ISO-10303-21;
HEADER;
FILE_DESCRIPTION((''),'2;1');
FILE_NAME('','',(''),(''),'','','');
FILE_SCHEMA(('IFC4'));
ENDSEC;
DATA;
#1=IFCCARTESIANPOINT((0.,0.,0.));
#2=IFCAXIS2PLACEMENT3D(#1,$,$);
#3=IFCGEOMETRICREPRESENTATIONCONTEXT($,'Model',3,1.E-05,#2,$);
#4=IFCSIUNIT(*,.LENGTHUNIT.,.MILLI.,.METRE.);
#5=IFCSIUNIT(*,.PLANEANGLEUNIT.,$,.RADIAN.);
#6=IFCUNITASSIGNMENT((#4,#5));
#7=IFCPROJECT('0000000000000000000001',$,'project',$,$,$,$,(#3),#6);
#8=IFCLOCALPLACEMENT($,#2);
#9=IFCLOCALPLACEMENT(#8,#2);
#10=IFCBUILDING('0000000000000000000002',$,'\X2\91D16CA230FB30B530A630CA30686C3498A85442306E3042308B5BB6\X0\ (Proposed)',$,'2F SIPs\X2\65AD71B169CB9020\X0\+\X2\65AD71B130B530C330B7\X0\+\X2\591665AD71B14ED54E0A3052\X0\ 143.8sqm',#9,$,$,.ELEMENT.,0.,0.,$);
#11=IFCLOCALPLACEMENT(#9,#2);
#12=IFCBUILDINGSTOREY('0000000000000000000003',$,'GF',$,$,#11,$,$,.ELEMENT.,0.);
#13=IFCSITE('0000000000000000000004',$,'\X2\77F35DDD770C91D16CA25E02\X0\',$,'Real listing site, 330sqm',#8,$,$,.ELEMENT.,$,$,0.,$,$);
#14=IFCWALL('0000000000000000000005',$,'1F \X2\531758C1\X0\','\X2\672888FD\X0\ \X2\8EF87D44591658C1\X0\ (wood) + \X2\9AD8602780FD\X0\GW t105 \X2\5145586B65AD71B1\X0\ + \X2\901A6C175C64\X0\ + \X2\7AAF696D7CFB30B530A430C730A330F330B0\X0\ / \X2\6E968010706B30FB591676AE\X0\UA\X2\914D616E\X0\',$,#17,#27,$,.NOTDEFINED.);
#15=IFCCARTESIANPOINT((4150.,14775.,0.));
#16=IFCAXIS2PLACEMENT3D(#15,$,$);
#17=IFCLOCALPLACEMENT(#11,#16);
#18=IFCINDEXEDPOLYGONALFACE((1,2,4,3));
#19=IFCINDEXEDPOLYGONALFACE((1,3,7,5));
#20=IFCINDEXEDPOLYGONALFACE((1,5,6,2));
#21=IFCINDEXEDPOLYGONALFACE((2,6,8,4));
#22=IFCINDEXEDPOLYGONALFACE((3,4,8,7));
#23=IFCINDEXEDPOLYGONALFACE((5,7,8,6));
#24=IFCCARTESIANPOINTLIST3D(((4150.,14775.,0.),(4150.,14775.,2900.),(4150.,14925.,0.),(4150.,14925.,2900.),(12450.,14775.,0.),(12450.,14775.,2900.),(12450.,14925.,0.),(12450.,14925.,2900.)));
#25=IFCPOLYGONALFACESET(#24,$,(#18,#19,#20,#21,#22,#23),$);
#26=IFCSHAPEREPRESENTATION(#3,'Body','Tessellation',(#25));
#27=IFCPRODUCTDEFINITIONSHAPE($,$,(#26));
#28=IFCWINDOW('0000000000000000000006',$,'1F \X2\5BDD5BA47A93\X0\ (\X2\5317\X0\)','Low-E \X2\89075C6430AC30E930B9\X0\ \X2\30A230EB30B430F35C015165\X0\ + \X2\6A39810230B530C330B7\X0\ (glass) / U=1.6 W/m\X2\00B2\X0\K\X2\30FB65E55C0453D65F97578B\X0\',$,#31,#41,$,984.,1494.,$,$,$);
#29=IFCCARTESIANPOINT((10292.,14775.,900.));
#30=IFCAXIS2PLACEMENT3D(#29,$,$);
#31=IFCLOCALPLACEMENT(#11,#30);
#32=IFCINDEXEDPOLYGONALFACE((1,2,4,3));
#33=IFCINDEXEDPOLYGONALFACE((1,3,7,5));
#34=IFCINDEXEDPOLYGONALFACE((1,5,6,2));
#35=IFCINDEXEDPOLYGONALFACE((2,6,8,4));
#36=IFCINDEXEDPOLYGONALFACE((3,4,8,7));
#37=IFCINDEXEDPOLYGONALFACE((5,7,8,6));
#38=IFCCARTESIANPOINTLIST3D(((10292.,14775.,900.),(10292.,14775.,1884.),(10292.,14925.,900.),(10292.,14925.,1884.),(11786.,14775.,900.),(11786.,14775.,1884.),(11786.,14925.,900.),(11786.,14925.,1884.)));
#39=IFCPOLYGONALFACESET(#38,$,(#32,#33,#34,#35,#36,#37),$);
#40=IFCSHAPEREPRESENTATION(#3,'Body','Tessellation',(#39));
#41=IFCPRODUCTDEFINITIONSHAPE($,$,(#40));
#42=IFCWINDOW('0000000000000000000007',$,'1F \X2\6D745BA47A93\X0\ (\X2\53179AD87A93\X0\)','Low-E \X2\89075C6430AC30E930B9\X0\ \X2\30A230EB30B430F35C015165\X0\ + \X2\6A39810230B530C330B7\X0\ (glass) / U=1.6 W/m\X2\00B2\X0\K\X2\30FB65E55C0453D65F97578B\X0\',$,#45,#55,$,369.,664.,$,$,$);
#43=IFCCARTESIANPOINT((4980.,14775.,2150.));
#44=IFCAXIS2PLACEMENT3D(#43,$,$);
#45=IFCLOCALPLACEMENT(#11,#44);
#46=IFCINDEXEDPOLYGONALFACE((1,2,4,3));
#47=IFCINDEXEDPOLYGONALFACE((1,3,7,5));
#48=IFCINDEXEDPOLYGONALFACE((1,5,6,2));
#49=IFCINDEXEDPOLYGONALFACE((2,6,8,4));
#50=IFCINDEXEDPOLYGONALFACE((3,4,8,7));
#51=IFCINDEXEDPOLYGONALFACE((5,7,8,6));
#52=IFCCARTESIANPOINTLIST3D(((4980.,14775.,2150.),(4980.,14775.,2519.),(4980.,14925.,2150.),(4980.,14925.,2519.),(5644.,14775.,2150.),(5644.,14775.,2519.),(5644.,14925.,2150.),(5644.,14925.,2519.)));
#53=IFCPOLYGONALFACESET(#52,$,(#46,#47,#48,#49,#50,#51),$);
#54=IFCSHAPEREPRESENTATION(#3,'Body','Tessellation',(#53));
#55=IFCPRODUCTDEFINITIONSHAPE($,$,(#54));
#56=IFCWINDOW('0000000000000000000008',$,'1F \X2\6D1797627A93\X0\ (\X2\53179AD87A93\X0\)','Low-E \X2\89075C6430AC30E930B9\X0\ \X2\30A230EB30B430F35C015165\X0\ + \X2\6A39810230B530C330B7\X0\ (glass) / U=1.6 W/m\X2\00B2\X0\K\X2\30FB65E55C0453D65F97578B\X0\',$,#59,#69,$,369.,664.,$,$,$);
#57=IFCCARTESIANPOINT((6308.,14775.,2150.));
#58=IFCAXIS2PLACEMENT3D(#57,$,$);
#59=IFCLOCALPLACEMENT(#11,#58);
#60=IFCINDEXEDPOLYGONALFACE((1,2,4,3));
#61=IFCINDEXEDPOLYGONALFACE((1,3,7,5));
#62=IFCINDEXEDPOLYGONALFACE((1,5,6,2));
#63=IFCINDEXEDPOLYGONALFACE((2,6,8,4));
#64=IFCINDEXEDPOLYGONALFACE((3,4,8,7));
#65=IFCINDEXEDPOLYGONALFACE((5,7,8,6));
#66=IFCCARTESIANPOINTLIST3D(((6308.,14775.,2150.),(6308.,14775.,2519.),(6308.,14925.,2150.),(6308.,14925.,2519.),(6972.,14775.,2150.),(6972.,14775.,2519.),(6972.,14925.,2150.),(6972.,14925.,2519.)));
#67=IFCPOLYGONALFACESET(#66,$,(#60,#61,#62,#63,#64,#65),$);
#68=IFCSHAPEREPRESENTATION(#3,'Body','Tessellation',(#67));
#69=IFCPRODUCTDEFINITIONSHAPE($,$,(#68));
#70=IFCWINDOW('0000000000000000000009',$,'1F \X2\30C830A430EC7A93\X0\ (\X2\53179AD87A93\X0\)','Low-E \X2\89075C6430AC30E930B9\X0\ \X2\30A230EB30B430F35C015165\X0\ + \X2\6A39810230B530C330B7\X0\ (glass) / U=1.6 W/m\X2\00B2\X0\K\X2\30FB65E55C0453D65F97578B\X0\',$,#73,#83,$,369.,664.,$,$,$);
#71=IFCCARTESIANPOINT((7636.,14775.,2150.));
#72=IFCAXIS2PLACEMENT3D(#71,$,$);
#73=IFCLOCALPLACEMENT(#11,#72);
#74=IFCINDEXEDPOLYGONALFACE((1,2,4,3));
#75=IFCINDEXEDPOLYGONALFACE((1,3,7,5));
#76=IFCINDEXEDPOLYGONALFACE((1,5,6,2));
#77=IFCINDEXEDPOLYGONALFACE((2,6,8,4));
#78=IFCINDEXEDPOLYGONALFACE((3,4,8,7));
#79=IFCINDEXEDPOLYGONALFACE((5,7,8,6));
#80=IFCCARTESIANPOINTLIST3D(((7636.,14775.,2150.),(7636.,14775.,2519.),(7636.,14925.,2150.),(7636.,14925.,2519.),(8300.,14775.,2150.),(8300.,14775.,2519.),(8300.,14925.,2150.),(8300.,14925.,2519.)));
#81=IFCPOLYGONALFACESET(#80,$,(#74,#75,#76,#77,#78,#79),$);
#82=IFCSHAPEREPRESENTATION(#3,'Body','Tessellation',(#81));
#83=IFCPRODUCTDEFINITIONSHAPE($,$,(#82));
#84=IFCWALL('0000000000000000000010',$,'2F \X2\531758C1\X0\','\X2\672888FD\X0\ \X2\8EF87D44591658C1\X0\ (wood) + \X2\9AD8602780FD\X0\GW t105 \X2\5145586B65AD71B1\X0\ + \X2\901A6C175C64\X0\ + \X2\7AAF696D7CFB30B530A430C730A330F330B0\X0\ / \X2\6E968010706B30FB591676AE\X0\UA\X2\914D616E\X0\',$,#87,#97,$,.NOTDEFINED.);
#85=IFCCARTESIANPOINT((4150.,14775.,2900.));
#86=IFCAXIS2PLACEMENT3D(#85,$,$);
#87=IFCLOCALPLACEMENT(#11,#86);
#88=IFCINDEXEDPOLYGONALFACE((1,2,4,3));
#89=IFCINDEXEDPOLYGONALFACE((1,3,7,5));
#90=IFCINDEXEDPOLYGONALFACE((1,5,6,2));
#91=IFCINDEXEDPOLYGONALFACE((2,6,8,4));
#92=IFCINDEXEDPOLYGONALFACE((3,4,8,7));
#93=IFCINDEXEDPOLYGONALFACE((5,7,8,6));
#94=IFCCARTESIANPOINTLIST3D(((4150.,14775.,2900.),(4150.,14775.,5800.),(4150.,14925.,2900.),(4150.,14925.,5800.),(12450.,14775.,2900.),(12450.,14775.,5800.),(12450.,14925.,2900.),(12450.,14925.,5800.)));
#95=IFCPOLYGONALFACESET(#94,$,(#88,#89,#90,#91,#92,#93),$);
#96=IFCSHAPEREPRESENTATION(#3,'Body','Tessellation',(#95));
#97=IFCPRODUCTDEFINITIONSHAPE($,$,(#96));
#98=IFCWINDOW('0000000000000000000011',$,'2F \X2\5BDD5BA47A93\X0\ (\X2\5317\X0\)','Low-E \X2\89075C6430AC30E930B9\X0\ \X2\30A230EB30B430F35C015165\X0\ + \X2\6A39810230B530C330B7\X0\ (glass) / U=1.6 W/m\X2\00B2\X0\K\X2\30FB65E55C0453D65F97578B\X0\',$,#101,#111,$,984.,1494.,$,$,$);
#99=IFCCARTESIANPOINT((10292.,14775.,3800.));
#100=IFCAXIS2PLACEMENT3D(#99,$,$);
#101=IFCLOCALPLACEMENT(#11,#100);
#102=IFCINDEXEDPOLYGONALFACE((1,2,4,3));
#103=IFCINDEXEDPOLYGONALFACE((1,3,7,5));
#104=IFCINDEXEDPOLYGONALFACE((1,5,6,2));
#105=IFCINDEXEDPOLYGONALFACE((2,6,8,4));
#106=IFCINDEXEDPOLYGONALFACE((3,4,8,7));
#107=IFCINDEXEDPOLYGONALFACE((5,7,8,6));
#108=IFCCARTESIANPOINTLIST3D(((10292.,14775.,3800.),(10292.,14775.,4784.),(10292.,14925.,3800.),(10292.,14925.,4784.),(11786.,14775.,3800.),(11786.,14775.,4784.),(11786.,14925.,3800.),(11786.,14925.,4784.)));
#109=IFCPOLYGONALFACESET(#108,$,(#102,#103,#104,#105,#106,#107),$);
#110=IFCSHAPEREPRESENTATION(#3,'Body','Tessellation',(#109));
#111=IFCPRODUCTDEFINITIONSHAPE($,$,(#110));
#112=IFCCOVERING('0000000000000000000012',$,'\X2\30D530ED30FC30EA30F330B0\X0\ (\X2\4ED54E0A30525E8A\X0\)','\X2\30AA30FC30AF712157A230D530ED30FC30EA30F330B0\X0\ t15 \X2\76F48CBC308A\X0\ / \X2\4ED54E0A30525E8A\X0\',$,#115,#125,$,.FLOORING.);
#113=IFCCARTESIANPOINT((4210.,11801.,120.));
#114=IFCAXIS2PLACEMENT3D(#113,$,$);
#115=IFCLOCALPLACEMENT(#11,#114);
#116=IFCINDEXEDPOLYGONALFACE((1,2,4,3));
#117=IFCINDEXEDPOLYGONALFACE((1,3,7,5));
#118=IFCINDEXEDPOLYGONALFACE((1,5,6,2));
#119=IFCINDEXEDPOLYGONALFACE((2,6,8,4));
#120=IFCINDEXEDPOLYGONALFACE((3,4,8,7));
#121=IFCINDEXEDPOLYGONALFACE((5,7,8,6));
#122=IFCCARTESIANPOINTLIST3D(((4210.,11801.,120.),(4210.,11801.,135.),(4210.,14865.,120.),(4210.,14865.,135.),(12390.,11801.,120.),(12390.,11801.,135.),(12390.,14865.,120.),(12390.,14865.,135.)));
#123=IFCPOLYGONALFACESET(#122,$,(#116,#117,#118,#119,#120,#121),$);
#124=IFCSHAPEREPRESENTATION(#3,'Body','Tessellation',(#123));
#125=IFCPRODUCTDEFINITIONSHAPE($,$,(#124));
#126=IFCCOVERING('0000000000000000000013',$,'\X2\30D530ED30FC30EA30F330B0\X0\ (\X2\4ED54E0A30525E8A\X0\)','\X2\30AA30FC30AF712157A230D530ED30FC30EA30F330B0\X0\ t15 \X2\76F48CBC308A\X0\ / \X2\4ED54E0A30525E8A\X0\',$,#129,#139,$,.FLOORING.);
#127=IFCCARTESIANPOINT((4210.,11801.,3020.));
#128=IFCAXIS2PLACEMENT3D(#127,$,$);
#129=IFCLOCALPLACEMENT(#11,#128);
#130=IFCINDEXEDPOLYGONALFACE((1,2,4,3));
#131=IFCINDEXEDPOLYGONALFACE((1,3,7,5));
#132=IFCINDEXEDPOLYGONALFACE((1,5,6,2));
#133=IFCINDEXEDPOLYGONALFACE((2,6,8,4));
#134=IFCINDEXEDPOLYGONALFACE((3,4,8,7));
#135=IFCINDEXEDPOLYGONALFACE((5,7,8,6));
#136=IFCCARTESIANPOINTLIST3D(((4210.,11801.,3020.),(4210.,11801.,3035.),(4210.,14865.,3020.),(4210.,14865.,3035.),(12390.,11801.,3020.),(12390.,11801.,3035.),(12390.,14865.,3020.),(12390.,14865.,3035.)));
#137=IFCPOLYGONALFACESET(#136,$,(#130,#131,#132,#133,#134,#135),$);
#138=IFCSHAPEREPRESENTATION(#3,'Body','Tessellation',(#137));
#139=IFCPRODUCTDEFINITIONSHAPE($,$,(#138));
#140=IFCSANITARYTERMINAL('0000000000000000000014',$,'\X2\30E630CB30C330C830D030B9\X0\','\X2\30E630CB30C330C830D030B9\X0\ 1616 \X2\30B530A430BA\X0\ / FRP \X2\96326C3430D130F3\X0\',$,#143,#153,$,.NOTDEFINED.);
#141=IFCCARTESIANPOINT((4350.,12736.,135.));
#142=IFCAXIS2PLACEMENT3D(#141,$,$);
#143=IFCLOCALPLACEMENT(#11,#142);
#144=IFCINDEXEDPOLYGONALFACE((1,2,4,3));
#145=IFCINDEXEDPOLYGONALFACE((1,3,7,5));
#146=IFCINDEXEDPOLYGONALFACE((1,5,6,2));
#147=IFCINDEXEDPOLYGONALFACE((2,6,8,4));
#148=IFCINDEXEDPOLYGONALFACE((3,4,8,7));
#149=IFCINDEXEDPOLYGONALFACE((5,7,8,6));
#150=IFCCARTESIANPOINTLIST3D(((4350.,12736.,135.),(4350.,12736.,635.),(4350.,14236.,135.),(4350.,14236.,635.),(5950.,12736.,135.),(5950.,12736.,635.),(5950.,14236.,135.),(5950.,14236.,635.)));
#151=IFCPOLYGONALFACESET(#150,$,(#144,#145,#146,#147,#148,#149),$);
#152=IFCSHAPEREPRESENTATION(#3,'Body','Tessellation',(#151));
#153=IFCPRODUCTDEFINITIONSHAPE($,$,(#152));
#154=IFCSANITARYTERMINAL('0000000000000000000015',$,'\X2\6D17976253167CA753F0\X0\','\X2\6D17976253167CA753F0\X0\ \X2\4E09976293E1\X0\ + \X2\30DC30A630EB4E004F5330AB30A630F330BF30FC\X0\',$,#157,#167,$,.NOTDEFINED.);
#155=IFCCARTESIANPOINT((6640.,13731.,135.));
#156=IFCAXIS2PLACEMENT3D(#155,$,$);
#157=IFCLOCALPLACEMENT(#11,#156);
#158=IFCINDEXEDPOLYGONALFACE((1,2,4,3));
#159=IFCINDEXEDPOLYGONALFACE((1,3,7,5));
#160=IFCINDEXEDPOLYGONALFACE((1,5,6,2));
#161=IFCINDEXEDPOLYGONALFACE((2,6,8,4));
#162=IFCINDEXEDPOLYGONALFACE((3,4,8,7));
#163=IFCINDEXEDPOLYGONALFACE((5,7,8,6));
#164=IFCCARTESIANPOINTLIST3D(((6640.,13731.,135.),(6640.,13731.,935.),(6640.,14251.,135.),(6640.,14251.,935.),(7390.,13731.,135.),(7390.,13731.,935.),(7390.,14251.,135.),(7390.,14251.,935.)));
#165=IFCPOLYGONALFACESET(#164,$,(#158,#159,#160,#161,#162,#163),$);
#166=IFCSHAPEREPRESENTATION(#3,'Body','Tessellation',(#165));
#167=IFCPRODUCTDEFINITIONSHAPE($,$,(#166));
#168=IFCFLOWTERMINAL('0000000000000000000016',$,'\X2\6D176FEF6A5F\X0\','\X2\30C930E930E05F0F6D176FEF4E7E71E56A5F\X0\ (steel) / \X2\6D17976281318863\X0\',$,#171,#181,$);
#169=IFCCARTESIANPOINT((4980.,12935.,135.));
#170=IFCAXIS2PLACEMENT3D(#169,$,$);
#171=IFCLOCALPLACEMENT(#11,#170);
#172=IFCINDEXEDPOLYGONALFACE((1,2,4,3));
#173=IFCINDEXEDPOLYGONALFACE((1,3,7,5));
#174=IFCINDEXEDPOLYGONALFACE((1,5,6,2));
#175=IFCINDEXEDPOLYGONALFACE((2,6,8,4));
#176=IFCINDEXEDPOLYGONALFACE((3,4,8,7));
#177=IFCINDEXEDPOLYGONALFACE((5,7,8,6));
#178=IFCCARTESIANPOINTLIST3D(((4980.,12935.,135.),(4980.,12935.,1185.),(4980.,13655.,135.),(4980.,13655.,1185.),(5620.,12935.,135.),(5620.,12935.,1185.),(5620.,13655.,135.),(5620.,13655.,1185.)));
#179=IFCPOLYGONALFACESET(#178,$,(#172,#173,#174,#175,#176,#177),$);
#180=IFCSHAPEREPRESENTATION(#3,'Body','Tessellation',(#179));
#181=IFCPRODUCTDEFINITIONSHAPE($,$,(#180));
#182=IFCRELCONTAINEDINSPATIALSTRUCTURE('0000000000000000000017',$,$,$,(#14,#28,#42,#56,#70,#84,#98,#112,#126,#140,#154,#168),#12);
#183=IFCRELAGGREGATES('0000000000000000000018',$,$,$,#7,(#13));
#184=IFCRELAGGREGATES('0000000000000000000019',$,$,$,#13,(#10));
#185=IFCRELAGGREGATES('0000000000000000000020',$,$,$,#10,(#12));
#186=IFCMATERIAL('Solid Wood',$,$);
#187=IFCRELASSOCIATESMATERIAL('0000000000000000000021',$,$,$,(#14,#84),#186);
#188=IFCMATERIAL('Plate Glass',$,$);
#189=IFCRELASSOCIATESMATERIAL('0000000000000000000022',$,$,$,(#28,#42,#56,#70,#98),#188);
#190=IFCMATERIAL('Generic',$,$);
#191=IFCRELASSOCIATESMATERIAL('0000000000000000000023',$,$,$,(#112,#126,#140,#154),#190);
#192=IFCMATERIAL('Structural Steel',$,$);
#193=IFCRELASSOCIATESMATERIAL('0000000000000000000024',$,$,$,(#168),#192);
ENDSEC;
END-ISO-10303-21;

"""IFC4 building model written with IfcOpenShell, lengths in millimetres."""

from ifc_helpers import new_model, si_unit, frame, frame_2d, origin, place, context, project, spatial, rectangle, extrude, material, element, fill, save


model = new_model("IFC4")

# Units and contexts
model_context = context("Model", 3, precision=1e-05, world=origin())
ifc_project = project(units=[si_unit("LENGTHUNIT", "METRE", prefix="MILLI"), si_unit("PLANEANGLEUNIT", "RADIAN")], contexts=[model_context])

# Site, building, storey
site_placement = place(None, origin())
site = spatial("IfcSite", under=ifc_project, at=site_placement, Name="石川県金沢市", ObjectType="Real listing site, 330sqm", CompositionType="ELEMENT", RefElevation=0.0)
building_placement = place(site_placement, origin())
building = spatial("IfcBuilding", under=site, at=building_placement, Name="金沢・サウナと水風呂のある家 (Proposed)", ObjectType="2F SIPs断熱構造+断熱サッシ+外断熱仕上げ 143.8sqm", CompositionType="ELEMENT", ElevationOfRefHeight=0.0, ElevationOfTerrain=0.0)
storey_placement = place(building_placement, origin())
storey = spatial("IfcBuildingStorey", under=building, at=storey_placement, Name="GF", CompositionType="ELEMENT", Elevation=0.0)

# Shared definitions
ifc_material_1 = material(Name="Solid Wood")

# Wall, openings, windows
wall_1_placement = place(storey_placement, frame((4150.0, 14775.0, 0.0)))
wall_1 = element("IfcWall", 1, at=wall_1_placement, inside=storey, material=ifc_material_1, Name="1F 北壁", Description="木製 軸組外壁 (wood) + 高性能GW t105 充填断熱 + 通気層 + 窯業系サイディング / 準耐火・外皮UA配慮", PredefinedType="NOTDEFINED", context=model_context, shape_type="SweptSolid", body=[
    extrude(rectangle(XDim=8300.0, YDim=150.0, at=frame_2d((4150.0, 75.0))), frame((4150.0, 14775.0, 0.0)), (0.0, 0.0, 1.0), 2900.0),
])
opening_1_placement = place(storey_placement, frame((10292.0, 14775.0, 900.0)))
opening_1 = element("IfcOpeningElement", 2, at=opening_1_placement, cuts=wall_1, PredefinedType="NOTDEFINED", context=model_context, shape_type="SweptSolid", body=[
    extrude(rectangle(XDim=1494.0, YDim=150.0, at=frame_2d((747.0, 75.0))), frame((10292.0, 14775.0, 900.0)), (0.0, 0.0, 1.0), 984.0),
])
opening_2_placement = place(storey_placement, frame((4980.0, 14775.0, 2150.0)))
opening_2 = element("IfcOpeningElement", 3, at=opening_2_placement, cuts=wall_1, PredefinedType="NOTDEFINED", context=model_context, shape_type="SweptSolid", body=[
    extrude(rectangle(XDim=664.0, YDim=150.0, at=frame_2d((332.0, 75.0))), frame((4980.0, 14775.0, 2150.0)), (0.0, 0.0, 1.0), 369.0),
])
opening_3_placement = place(storey_placement, frame((6308.0, 14775.0, 2150.0)))
opening_3 = element("IfcOpeningElement", 4, at=opening_3_placement, cuts=wall_1, PredefinedType="NOTDEFINED", context=model_context, shape_type="SweptSolid", body=[
    extrude(rectangle(XDim=664.0, YDim=150.0, at=frame_2d((332.0, 75.0))), frame((6308.0, 14775.0, 2150.0)), (0.0, 0.0, 1.0), 369.0),
])
opening_4_placement = place(storey_placement, frame((7636.0, 14775.0, 2150.0)))
opening_4 = element("IfcOpeningElement", 5, at=opening_4_placement, cuts=wall_1, PredefinedType="NOTDEFINED", context=model_context, shape_type="SweptSolid", body=[
    extrude(rectangle(XDim=664.0, YDim=150.0, at=frame_2d((332.0, 75.0))), frame((7636.0, 14775.0, 2150.0)), (0.0, 0.0, 1.0), 369.0),
])
ifc_material_2 = material(Name="Plate Glass")
window_1_placement = place(storey_placement, frame((10292.0, 14775.0, 900.0)))
window_1 = element("IfcWindow", 6, at=window_1_placement, inside=storey, material=ifc_material_2, Name="1F 寝室窓 (北)", Description="Low-E 複層ガラス アルゴン封入 + 樹脂サッシ (glass) / U=1.6 W/m²K・日射取得型", OverallHeight=984.0, OverallWidth=1494.0, context=model_context, shape_type="SweptSolid", body=[
    extrude(rectangle(XDim=1494.0, YDim=150.0, at=frame_2d((747.0, 75.0))), frame((10292.0, 14775.0, 900.0)), (0.0, 0.0, 1.0), 984.0),
])
fill(opening_1, window_1)
window_2_placement = place(storey_placement, frame((4980.0, 14775.0, 2150.0)))
window_2 = element("IfcWindow", 7, at=window_2_placement, inside=storey, material=ifc_material_2, Name="1F 浴室窓 (北高窓)", Description="Low-E 複層ガラス アルゴン封入 + 樹脂サッシ (glass) / U=1.6 W/m²K・日射取得型", OverallHeight=369.0, OverallWidth=664.0, context=model_context, shape_type="SweptSolid", body=[
    extrude(rectangle(XDim=664.0, YDim=150.0, at=frame_2d((332.0, 75.0))), frame((4980.0, 14775.0, 2150.0)), (0.0, 0.0, 1.0), 369.0),
])
fill(opening_2, window_2)
window_3_placement = place(storey_placement, frame((6308.0, 14775.0, 2150.0)))
window_3 = element("IfcWindow", 8, at=window_3_placement, inside=storey, material=ifc_material_2, Name="1F 洗面窓 (北高窓)", Description="Low-E 複層ガラス アルゴン封入 + 樹脂サッシ (glass) / U=1.6 W/m²K・日射取得型", OverallHeight=369.0, OverallWidth=664.0, context=model_context, shape_type="SweptSolid", body=[
    extrude(rectangle(XDim=664.0, YDim=150.0, at=frame_2d((332.0, 75.0))), frame((6308.0, 14775.0, 2150.0)), (0.0, 0.0, 1.0), 369.0),
])
fill(opening_3, window_3)
window_4_placement = place(storey_placement, frame((7636.0, 14775.0, 2150.0)))
window_4 = element("IfcWindow", 9, at=window_4_placement, inside=storey, material=ifc_material_2, Name="1F トイレ窓 (北高窓)", Description="Low-E 複層ガラス アルゴン封入 + 樹脂サッシ (glass) / U=1.6 W/m²K・日射取得型", OverallHeight=369.0, OverallWidth=664.0, context=model_context, shape_type="SweptSolid", body=[
    extrude(rectangle(XDim=664.0, YDim=150.0, at=frame_2d((332.0, 75.0))), frame((7636.0, 14775.0, 2150.0)), (0.0, 0.0, 1.0), 369.0),
])
fill(opening_4, window_4)

# Wall, opening, window
wall_2_placement = place(storey_placement, frame((4150.0, 14775.0, 2900.0)))
wall_2 = element("IfcWall", 10, at=wall_2_placement, inside=storey, material=ifc_material_1, Name="2F 北壁", Description="木製 軸組外壁 (wood) + 高性能GW t105 充填断熱 + 通気層 + 窯業系サイディング / 準耐火・外皮UA配慮", PredefinedType="NOTDEFINED", context=model_context, shape_type="SweptSolid", body=[
    extrude(rectangle(XDim=8300.0, YDim=150.0, at=frame_2d((4150.0, 75.0))), frame((4150.0, 14775.0, 2900.0)), (0.0, 0.0, 1.0), 2900.0),
])
opening_5_placement = place(storey_placement, frame((10292.0, 14775.0, 3800.0)))
opening_5 = element("IfcOpeningElement", 11, at=opening_5_placement, cuts=wall_2, PredefinedType="NOTDEFINED", context=model_context, shape_type="SweptSolid", body=[
    extrude(rectangle(XDim=1494.0, YDim=150.0, at=frame_2d((747.0, 75.0))), frame((10292.0, 14775.0, 3800.0)), (0.0, 0.0, 1.0), 984.0),
])
window_5_placement = place(storey_placement, frame((10292.0, 14775.0, 3800.0)))
window_5 = element("IfcWindow", 12, at=window_5_placement, inside=storey, material=ifc_material_2, Name="2F 寝室窓 (北)", Description="Low-E 複層ガラス アルゴン封入 + 樹脂サッシ (glass) / U=1.6 W/m²K・日射取得型", OverallHeight=984.0, OverallWidth=1494.0, context=model_context, shape_type="SweptSolid", body=[
    extrude(rectangle(XDim=1494.0, YDim=150.0, at=frame_2d((747.0, 75.0))), frame((10292.0, 14775.0, 3800.0)), (0.0, 0.0, 1.0), 984.0),
])
fill(opening_5, window_5)

# Coverings
ifc_material_3 = material(Name="Generic")
covering_1_placement = place(storey_placement, frame((4210.0, 11801.0, 120.0)))
element("IfcCovering", 13, at=covering_1_placement, inside=storey, material=ifc_material_3, Name="フローリング (仕上げ床)", Description="オーク無垢フローリング t15 直貼り / 仕上げ床", PredefinedType="FLOORING", context=model_context, shape_type="SweptSolid", body=[
    extrude(rectangle(XDim=8180.0, YDim=3064.0, at=frame_2d((4090.0, 1532.0))), frame((4210.0, 11801.0, 120.0)), (0.0, 0.0, 1.0), 15.0),
])
covering_2_placement = place(storey_placement, frame((4210.0, 11801.0, 3020.0)))
element("IfcCovering", 14, at=covering_2_placement, inside=storey, material=ifc_material_3, Name="フローリング (仕上げ床)", Description="オーク無垢フローリング t15 直貼り / 仕上げ床", PredefinedType="FLOORING", context=model_context, shape_type="SweptSolid", body=[
    extrude(rectangle(XDim=8180.0, YDim=3064.0, at=frame_2d((4090.0, 1532.0))), frame((4210.0, 11801.0, 3020.0)), (0.0, 0.0, 1.0), 15.0),
])

# Sanitary terminals
sanitary_terminal_1_placement = place(storey_placement, frame((4350.0, 12736.0, 135.0)))
element("IfcSanitaryTerminal", 15, at=sanitary_terminal_1_placement, inside=storey, material=ifc_material_3, Name="ユニットバス", Description="ユニットバス 1616 サイズ / FRP 防水パン", PredefinedType="NOTDEFINED", context=model_context, shape_type="SweptSolid", body=[
    extrude(rectangle(XDim=1600.0, YDim=1500.0, at=frame_2d((800.0, 750.0))), frame((4350.0, 12736.0, 135.0)), (0.0, 0.0, 1.0), 500.0),
])
sanitary_terminal_2_placement = place(storey_placement, frame((6640.0, 13731.0, 135.0)))
element("IfcSanitaryTerminal", 16, at=sanitary_terminal_2_placement, inside=storey, material=ifc_material_3, Name="洗面化粧台", Description="洗面化粧台 三面鏡 + ボウル一体カウンター", PredefinedType="NOTDEFINED", context=model_context, shape_type="SweptSolid", body=[
    extrude(rectangle(XDim=750.0, YDim=520.0, at=frame_2d((375.0, 260.0))), frame((6640.0, 13731.0, 135.0)), (0.0, 0.0, 1.0), 800.0),
])

# Flow terminal
ifc_material_4 = material(Name="Structural Steel")
flow_terminal_placement = place(storey_placement, frame((4980.0, 12935.0, 135.0)))
element("IfcFlowTerminal", 17, at=flow_terminal_placement, inside=storey, material=ifc_material_4, Name="洗濯機", Description="ドラム式洗濯乾燥機 (steel) / 洗面脱衣", context=model_context, shape_type="SweptSolid", body=[
    extrude(rectangle(XDim=640.0, YDim=720.0, at=frame_2d((320.0, 360.0))), frame((4980.0, 12935.0, 135.0)), (0.0, 0.0, 1.0), 1050.0),
])

save(model, "model.ifc")
